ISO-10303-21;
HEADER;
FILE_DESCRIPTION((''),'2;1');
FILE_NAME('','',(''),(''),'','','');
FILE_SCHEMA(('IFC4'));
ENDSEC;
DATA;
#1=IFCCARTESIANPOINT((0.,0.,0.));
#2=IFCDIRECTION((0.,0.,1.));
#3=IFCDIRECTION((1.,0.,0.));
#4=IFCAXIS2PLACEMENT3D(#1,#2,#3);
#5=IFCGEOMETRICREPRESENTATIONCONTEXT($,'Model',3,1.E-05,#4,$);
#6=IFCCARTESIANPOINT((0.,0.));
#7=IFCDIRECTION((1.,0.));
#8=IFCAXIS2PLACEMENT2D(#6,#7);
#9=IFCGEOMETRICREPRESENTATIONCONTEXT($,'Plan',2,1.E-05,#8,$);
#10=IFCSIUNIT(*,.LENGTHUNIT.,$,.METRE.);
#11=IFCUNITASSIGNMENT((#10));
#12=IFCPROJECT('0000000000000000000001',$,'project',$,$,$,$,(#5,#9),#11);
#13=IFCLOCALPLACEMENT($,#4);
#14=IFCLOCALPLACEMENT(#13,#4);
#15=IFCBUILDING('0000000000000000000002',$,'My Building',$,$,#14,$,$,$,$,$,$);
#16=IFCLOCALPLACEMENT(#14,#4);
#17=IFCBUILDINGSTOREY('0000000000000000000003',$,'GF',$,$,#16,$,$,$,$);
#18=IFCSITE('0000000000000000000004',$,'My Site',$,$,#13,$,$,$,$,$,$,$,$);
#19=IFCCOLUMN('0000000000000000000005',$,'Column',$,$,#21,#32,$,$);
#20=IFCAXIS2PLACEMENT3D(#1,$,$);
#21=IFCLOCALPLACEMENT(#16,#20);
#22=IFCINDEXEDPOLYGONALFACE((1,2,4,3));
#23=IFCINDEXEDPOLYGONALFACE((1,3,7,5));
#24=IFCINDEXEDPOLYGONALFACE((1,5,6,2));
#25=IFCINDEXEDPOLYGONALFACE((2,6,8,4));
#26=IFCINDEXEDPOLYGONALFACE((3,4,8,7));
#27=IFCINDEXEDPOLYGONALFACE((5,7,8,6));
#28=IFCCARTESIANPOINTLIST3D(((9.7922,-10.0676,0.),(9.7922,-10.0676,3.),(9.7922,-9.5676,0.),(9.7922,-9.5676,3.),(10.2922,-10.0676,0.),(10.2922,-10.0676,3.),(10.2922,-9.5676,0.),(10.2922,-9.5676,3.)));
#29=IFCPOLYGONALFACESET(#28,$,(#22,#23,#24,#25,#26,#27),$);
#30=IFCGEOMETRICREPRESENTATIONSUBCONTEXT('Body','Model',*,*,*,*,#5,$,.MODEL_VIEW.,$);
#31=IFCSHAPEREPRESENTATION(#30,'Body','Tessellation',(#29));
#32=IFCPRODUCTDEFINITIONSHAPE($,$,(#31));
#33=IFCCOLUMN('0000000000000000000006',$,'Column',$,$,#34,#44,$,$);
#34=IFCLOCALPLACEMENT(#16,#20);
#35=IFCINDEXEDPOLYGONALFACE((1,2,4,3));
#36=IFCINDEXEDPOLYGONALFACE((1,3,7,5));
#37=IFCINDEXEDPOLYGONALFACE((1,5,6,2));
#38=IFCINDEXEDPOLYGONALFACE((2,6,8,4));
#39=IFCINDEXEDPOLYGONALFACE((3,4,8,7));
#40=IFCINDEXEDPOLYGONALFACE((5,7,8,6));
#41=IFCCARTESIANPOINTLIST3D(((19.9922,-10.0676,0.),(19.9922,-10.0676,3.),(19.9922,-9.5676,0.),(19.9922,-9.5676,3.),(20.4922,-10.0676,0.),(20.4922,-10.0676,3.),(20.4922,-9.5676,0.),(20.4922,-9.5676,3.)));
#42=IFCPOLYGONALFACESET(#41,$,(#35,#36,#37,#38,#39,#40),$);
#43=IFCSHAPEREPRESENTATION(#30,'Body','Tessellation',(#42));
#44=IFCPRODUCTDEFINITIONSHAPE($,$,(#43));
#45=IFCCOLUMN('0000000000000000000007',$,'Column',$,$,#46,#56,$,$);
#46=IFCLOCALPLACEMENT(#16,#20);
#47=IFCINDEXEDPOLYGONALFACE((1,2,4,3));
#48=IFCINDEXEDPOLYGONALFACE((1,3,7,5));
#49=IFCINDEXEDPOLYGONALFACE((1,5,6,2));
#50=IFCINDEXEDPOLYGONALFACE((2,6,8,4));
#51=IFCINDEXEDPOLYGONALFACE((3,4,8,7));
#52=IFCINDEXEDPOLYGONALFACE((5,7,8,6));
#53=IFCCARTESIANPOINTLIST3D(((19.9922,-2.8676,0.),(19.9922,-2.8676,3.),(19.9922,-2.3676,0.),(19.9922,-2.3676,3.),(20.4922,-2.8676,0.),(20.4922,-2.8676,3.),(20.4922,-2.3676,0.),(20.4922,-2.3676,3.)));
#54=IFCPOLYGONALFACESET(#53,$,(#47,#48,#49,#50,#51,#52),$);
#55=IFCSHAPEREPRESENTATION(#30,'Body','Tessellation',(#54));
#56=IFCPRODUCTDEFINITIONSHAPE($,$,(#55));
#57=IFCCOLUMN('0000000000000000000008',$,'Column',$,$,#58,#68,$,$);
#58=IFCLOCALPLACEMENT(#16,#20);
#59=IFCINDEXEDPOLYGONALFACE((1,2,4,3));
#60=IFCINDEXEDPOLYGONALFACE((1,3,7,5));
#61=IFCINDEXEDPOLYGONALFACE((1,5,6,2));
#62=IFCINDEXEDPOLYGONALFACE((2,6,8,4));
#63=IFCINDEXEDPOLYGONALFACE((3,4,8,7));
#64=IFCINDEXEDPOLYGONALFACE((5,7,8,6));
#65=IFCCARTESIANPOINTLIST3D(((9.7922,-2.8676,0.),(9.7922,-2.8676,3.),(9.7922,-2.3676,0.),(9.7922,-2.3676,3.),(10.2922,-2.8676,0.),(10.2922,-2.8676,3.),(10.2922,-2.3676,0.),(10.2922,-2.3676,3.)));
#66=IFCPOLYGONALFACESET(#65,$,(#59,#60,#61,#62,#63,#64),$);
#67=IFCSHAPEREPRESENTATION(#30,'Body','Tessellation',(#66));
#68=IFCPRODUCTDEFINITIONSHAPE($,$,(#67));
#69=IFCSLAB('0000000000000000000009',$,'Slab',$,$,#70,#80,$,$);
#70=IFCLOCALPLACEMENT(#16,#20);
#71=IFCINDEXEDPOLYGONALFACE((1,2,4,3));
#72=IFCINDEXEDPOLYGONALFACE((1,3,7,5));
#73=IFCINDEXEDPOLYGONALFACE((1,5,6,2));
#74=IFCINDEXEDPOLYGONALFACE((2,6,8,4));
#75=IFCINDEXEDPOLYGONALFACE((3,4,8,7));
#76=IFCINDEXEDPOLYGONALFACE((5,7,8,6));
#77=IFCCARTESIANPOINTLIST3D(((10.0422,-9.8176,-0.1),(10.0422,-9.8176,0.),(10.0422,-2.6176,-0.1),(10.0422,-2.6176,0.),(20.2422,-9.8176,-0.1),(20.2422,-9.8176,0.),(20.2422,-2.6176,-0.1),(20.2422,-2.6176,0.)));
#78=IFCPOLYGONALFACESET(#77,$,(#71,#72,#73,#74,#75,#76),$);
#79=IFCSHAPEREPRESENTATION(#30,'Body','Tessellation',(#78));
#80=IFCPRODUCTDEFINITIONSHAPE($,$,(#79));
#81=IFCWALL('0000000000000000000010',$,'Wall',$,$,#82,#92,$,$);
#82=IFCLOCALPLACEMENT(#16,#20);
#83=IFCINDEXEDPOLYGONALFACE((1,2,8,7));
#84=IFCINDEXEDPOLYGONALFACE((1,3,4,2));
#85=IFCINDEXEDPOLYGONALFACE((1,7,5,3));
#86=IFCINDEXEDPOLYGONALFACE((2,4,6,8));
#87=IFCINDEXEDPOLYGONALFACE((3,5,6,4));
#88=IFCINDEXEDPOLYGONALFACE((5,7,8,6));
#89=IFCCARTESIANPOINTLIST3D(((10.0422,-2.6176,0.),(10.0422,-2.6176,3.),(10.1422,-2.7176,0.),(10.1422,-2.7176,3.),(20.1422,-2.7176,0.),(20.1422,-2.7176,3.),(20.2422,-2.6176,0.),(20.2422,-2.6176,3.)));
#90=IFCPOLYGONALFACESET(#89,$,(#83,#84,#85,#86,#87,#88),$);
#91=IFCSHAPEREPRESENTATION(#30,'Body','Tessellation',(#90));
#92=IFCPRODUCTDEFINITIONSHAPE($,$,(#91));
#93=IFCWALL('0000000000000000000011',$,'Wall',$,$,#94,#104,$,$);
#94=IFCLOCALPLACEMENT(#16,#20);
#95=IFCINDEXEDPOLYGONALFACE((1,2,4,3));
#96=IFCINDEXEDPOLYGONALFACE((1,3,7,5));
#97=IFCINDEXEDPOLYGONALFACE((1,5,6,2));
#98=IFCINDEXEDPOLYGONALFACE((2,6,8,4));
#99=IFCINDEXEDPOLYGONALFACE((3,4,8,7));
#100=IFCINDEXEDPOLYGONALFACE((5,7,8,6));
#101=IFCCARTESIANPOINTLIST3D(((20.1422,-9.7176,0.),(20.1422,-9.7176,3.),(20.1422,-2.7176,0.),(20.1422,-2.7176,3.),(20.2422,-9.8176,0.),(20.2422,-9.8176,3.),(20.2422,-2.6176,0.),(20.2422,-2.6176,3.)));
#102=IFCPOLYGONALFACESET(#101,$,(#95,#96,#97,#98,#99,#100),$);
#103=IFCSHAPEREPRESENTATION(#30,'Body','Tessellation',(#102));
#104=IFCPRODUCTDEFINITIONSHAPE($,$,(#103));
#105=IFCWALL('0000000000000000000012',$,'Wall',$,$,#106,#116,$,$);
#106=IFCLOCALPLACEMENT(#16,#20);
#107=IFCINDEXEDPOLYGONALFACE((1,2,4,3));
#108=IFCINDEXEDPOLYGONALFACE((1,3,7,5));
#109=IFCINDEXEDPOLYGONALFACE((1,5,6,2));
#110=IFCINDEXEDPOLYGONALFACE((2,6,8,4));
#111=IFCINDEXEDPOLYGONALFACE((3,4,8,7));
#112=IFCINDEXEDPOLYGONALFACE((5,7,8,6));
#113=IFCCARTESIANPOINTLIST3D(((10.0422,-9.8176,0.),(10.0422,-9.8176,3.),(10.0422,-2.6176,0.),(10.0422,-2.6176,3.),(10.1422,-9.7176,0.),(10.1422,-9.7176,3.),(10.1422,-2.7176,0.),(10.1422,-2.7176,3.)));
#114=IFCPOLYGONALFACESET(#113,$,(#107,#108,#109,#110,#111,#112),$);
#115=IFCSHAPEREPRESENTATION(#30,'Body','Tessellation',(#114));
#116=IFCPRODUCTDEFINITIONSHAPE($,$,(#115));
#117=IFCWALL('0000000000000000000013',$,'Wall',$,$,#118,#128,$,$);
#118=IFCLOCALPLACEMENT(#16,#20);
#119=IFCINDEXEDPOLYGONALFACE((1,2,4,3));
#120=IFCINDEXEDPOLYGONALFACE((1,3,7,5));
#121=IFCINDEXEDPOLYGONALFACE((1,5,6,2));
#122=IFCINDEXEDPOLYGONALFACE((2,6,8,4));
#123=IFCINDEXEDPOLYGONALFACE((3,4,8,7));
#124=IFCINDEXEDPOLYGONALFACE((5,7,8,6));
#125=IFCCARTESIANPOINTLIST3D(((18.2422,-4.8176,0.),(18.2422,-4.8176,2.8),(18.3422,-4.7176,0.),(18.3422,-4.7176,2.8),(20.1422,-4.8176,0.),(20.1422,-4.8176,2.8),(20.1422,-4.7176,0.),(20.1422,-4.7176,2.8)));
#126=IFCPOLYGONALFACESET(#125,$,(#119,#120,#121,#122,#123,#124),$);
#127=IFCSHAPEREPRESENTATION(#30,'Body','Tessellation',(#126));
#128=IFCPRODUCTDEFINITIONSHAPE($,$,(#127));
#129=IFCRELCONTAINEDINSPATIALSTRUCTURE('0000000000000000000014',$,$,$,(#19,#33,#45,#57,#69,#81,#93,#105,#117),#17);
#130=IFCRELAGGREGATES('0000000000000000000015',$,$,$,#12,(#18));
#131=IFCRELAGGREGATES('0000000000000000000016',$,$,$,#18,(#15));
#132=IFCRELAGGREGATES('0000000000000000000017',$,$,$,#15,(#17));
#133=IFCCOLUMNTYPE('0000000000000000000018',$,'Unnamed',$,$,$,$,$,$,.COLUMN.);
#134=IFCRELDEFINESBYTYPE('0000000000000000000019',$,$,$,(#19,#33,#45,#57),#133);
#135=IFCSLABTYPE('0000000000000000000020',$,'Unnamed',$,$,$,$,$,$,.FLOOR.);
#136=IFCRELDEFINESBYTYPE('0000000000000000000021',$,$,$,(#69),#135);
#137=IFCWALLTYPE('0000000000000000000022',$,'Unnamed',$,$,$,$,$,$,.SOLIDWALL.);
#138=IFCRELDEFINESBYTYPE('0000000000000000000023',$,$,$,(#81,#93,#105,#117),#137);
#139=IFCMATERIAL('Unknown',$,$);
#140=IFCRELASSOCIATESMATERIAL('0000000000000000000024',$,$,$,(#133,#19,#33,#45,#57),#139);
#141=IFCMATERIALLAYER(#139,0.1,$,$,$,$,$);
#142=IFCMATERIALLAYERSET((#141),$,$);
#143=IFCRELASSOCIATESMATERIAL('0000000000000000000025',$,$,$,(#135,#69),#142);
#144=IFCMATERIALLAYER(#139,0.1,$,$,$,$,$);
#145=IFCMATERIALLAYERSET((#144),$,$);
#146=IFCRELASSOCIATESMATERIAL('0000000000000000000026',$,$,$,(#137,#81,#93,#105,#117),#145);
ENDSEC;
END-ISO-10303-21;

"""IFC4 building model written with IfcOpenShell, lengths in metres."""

from ifc_helpers import new_model, si_unit, frame, origin_with_axes, origin_2d_with_axis, place, context, subcontext, project, spatial, line, indexed_curve, rectangle, outline, extrude, material, layer, layer_set, layer_usage, material_profile, profile_set, profile_usage, type_object, element, save


model = new_model("IFC4")

# Units and contexts
model_context = context("Model", 3, precision=1e-05, world=origin_with_axes())
plan_context = context("Plan", 2, precision=1e-05, world=origin_2d_with_axis())
body_context_1 = subcontext(model_context, "Body", "Model", "MODEL_VIEW")
ifc_project = project(units=[si_unit("LENGTHUNIT", "METRE")], contexts=[model_context, plan_context])

# Site, building, storey
site_placement = place(None, origin_with_axes())
site = spatial("IfcSite", under=ifc_project, at=site_placement, Name="My Site")
building_placement = place(site_placement, origin_with_axes())
building = spatial("IfcBuilding", under=site, at=building_placement, Name="My Building")
storey_placement = place(building_placement, origin_with_axes())
storey = spatial("IfcBuildingStorey", under=building, at=storey_placement, Name="GF")

# Columns
ifc_material = material(Name="Unknown")
ifc_material_profile = material_profile(ifc_material, rectangle(XDim=0.5, YDim=0.5))
ifc_profile_set = profile_set([ifc_material_profile])
ifc_profile_usage_1 = profile_usage(ifc_profile_set, cardinal=5)
column_type = type_object("IfcColumnType", Name="Unnamed", PredefinedType="COLUMN", material=ifc_profile_set)
column_1_placement = place(storey_placement, frame((10.0422, -9.8176, 0.0), z_axis=(0.0, 0.0, 1.0), x_axis=(1.0, 0.0, 0.0)))
element("IfcColumn", 1, at=column_1_placement, inside=storey, type_object=column_type, material=ifc_profile_usage_1, Name="Column", context=body_context_1, shape_type="SweptSolid", body=[
    extrude(rectangle(XDim=0.5, YDim=0.5), origin_with_axes(), (0.0, 0.0, 1.0), 3.0),
])
ifc_profile_usage_2 = profile_usage(ifc_profile_set, cardinal=5)
column_2_placement = place(storey_placement, frame((20.2422, -9.8176, 0.0), z_axis=(0.0, 0.0, 1.0), x_axis=(1.0, 0.0, 0.0)))
element("IfcColumn", 2, at=column_2_placement, inside=storey, type_object=column_type, material=ifc_profile_usage_2, Name="Column", context=body_context_1, shape_type="SweptSolid", body=[
    extrude(rectangle(XDim=0.5, YDim=0.5), origin_with_axes(), (0.0, 0.0, 1.0), 3.0),
])
ifc_profile_usage_3 = profile_usage(ifc_profile_set, cardinal=5)
column_3_placement = place(storey_placement, frame((20.2422, -2.6176, 0.0), z_axis=(0.0, 0.0, 1.0), x_axis=(1.0, 0.0, 0.0)))
element("IfcColumn", 3, at=column_3_placement, inside=storey, type_object=column_type, material=ifc_profile_usage_3, Name="Column", context=body_context_1, shape_type="SweptSolid", body=[
    extrude(rectangle(XDim=0.5, YDim=0.5), origin_with_axes(), (0.0, 0.0, 1.0), 3.0),
])
ifc_profile_usage_4 = profile_usage(ifc_profile_set, cardinal=5)
column_4_placement = place(storey_placement, frame((10.0422, -2.6176, 0.0), z_axis=(0.0, 0.0, 1.0), x_axis=(1.0, 0.0, 0.0)))
element("IfcColumn", 4, at=column_4_placement, inside=storey, type_object=column_type, material=ifc_profile_usage_4, Name="Column", context=body_context_1, shape_type="SweptSolid", body=[
    extrude(rectangle(XDim=0.5, YDim=0.5), origin_with_axes(), (0.0, 0.0, 1.0), 3.0),
])

# Slab
ifc_layer_1 = layer(ifc_material, 0.1)
ifc_layer_set_1 = layer_set([ifc_layer_1])
ifc_layer_usage_1 = layer_usage(ifc_layer_set_1, "AXIS3", "POSITIVE", -0.1)
slab_type = type_object("IfcSlabType", Name="Unnamed", PredefinedType="FLOOR", material=ifc_layer_set_1)
slab_placement = place(storey_placement, frame((10.0422, -2.6176, 0.0), z_axis=(0.0, 0.0, 1.0), x_axis=(1.0, 0.0, 0.0)))
element("IfcSlab", 5, at=slab_placement, inside=storey, type_object=slab_type, material=ifc_layer_usage_1, Name="Slab", context=body_context_1, shape_type="SweptSolid", body=[
    extrude(outline(indexed_curve([(0.0, 0.0), (10.2, 0.0), (10.2, -7.2), (0.0, -7.2), (0.0, 0.0)])), frame((0.0, 0.0, -0.1), z_axis=(0.0, 0.0, 1.0), x_axis=(1.0, 0.0, 0.0)), (0.0, 0.0, 1.0), 0.1),
])

# Walls
ifc_layer_2 = layer(ifc_material, 0.1)
ifc_layer_set_2 = layer_set([ifc_layer_2])
ifc_layer_usage_2 = layer_usage(ifc_layer_set_2, "AXIS2", "POSITIVE", 0.0)
wall_type = type_object("IfcWallType", Name="Unnamed", PredefinedType="SOLIDWALL", material=ifc_layer_set_2)
wall_1_placement = place(storey_placement, frame((10.1422, -2.7176, 0.0), z_axis=(0.0, 0.0, 1.0), x_axis=(1.0, 0.0, 0.0)))
element("IfcWall", 6, at=wall_1_placement, inside=storey, type_object=wall_type, material=ifc_layer_usage_2, Name="Wall", context=body_context_1, shape_type="SweptSolid", body=[
    extrude(outline(indexed_curve([(0.0, 0.0), (-0.1, 0.1), (10.1, 0.1), (10.0, 0.0)], segments=[line(1, 2, 3, 4, 1)])), origin_with_axes(), (0.0, 0.0, 1.0), 3.0),
])
ifc_layer_usage_3 = layer_usage(ifc_layer_set_2, "AXIS2", "POSITIVE", 0.0)
wall_2_placement = place(storey_placement, frame((20.1422, -2.7176, 0.0), z_axis=(0.0, 0.0, 1.0), x_axis=(0.0, -1.0, 0.0)))
element("IfcWall", 7, at=wall_2_placement, inside=storey, type_object=wall_type, material=ifc_layer_usage_3, Name="Wall", context=body_context_1, shape_type="SweptSolid", body=[
    extrude(outline(indexed_curve([(0.0, 0.0), (-0.1, 0.1), (7.1, 0.1), (7.0, 0.0)], segments=[line(1, 2, 3, 4, 1)])), origin_with_axes(), (0.0, 0.0, 1.0), 3.0),
])
ifc_layer_usage_4 = layer_usage(ifc_layer_set_2, "AXIS2", "POSITIVE", 0.0)
wall_3_placement = place(storey_placement, frame((10.1422, -9.8176, 0.0), z_axis=(0.0, 0.0, 1.0), x_axis=(0.0, 1.0, 0.0)))
element("IfcWall", 8, at=wall_3_placement, inside=storey, type_object=wall_type, material=ifc_layer_usage_4, Name="Wall", context=body_context_1, shape_type="SweptSolid", body=[
    extrude(outline(indexed_curve([(0.1, 0.0), (0.0, 0.1), (7.2, 0.1), (7.1, 0.0)], segments=[line(1, 2, 3, 4, 1)])), origin_with_axes(), (0.0, 0.0, 1.0), 3.0),
])
ifc_layer_usage_5 = layer_usage(ifc_layer_set_2, "AXIS2", "POSITIVE", 0.0)
wall_4_placement = place(storey_placement, frame((20.1422, -4.7176, 0.0), z_axis=(0.0, 0.0, 1.0), x_axis=(-1.0, 0.0, 0.0)))
element("IfcWall", 9, at=wall_4_placement, inside=storey, type_object=wall_type, material=ifc_layer_usage_5, Name="Wall", context=body_context_1, shape_type="SweptSolid", body=[
    extrude(outline(indexed_curve([(0.0, 0.0), (0.0, 0.1), (1.9, 0.1), (1.8, 0.0)], segments=[line(1, 2, 3, 4, 1)])), origin_with_axes(), (0.0, 0.0, 1.0), 2.8),
])

save(model, "model.ifc")
